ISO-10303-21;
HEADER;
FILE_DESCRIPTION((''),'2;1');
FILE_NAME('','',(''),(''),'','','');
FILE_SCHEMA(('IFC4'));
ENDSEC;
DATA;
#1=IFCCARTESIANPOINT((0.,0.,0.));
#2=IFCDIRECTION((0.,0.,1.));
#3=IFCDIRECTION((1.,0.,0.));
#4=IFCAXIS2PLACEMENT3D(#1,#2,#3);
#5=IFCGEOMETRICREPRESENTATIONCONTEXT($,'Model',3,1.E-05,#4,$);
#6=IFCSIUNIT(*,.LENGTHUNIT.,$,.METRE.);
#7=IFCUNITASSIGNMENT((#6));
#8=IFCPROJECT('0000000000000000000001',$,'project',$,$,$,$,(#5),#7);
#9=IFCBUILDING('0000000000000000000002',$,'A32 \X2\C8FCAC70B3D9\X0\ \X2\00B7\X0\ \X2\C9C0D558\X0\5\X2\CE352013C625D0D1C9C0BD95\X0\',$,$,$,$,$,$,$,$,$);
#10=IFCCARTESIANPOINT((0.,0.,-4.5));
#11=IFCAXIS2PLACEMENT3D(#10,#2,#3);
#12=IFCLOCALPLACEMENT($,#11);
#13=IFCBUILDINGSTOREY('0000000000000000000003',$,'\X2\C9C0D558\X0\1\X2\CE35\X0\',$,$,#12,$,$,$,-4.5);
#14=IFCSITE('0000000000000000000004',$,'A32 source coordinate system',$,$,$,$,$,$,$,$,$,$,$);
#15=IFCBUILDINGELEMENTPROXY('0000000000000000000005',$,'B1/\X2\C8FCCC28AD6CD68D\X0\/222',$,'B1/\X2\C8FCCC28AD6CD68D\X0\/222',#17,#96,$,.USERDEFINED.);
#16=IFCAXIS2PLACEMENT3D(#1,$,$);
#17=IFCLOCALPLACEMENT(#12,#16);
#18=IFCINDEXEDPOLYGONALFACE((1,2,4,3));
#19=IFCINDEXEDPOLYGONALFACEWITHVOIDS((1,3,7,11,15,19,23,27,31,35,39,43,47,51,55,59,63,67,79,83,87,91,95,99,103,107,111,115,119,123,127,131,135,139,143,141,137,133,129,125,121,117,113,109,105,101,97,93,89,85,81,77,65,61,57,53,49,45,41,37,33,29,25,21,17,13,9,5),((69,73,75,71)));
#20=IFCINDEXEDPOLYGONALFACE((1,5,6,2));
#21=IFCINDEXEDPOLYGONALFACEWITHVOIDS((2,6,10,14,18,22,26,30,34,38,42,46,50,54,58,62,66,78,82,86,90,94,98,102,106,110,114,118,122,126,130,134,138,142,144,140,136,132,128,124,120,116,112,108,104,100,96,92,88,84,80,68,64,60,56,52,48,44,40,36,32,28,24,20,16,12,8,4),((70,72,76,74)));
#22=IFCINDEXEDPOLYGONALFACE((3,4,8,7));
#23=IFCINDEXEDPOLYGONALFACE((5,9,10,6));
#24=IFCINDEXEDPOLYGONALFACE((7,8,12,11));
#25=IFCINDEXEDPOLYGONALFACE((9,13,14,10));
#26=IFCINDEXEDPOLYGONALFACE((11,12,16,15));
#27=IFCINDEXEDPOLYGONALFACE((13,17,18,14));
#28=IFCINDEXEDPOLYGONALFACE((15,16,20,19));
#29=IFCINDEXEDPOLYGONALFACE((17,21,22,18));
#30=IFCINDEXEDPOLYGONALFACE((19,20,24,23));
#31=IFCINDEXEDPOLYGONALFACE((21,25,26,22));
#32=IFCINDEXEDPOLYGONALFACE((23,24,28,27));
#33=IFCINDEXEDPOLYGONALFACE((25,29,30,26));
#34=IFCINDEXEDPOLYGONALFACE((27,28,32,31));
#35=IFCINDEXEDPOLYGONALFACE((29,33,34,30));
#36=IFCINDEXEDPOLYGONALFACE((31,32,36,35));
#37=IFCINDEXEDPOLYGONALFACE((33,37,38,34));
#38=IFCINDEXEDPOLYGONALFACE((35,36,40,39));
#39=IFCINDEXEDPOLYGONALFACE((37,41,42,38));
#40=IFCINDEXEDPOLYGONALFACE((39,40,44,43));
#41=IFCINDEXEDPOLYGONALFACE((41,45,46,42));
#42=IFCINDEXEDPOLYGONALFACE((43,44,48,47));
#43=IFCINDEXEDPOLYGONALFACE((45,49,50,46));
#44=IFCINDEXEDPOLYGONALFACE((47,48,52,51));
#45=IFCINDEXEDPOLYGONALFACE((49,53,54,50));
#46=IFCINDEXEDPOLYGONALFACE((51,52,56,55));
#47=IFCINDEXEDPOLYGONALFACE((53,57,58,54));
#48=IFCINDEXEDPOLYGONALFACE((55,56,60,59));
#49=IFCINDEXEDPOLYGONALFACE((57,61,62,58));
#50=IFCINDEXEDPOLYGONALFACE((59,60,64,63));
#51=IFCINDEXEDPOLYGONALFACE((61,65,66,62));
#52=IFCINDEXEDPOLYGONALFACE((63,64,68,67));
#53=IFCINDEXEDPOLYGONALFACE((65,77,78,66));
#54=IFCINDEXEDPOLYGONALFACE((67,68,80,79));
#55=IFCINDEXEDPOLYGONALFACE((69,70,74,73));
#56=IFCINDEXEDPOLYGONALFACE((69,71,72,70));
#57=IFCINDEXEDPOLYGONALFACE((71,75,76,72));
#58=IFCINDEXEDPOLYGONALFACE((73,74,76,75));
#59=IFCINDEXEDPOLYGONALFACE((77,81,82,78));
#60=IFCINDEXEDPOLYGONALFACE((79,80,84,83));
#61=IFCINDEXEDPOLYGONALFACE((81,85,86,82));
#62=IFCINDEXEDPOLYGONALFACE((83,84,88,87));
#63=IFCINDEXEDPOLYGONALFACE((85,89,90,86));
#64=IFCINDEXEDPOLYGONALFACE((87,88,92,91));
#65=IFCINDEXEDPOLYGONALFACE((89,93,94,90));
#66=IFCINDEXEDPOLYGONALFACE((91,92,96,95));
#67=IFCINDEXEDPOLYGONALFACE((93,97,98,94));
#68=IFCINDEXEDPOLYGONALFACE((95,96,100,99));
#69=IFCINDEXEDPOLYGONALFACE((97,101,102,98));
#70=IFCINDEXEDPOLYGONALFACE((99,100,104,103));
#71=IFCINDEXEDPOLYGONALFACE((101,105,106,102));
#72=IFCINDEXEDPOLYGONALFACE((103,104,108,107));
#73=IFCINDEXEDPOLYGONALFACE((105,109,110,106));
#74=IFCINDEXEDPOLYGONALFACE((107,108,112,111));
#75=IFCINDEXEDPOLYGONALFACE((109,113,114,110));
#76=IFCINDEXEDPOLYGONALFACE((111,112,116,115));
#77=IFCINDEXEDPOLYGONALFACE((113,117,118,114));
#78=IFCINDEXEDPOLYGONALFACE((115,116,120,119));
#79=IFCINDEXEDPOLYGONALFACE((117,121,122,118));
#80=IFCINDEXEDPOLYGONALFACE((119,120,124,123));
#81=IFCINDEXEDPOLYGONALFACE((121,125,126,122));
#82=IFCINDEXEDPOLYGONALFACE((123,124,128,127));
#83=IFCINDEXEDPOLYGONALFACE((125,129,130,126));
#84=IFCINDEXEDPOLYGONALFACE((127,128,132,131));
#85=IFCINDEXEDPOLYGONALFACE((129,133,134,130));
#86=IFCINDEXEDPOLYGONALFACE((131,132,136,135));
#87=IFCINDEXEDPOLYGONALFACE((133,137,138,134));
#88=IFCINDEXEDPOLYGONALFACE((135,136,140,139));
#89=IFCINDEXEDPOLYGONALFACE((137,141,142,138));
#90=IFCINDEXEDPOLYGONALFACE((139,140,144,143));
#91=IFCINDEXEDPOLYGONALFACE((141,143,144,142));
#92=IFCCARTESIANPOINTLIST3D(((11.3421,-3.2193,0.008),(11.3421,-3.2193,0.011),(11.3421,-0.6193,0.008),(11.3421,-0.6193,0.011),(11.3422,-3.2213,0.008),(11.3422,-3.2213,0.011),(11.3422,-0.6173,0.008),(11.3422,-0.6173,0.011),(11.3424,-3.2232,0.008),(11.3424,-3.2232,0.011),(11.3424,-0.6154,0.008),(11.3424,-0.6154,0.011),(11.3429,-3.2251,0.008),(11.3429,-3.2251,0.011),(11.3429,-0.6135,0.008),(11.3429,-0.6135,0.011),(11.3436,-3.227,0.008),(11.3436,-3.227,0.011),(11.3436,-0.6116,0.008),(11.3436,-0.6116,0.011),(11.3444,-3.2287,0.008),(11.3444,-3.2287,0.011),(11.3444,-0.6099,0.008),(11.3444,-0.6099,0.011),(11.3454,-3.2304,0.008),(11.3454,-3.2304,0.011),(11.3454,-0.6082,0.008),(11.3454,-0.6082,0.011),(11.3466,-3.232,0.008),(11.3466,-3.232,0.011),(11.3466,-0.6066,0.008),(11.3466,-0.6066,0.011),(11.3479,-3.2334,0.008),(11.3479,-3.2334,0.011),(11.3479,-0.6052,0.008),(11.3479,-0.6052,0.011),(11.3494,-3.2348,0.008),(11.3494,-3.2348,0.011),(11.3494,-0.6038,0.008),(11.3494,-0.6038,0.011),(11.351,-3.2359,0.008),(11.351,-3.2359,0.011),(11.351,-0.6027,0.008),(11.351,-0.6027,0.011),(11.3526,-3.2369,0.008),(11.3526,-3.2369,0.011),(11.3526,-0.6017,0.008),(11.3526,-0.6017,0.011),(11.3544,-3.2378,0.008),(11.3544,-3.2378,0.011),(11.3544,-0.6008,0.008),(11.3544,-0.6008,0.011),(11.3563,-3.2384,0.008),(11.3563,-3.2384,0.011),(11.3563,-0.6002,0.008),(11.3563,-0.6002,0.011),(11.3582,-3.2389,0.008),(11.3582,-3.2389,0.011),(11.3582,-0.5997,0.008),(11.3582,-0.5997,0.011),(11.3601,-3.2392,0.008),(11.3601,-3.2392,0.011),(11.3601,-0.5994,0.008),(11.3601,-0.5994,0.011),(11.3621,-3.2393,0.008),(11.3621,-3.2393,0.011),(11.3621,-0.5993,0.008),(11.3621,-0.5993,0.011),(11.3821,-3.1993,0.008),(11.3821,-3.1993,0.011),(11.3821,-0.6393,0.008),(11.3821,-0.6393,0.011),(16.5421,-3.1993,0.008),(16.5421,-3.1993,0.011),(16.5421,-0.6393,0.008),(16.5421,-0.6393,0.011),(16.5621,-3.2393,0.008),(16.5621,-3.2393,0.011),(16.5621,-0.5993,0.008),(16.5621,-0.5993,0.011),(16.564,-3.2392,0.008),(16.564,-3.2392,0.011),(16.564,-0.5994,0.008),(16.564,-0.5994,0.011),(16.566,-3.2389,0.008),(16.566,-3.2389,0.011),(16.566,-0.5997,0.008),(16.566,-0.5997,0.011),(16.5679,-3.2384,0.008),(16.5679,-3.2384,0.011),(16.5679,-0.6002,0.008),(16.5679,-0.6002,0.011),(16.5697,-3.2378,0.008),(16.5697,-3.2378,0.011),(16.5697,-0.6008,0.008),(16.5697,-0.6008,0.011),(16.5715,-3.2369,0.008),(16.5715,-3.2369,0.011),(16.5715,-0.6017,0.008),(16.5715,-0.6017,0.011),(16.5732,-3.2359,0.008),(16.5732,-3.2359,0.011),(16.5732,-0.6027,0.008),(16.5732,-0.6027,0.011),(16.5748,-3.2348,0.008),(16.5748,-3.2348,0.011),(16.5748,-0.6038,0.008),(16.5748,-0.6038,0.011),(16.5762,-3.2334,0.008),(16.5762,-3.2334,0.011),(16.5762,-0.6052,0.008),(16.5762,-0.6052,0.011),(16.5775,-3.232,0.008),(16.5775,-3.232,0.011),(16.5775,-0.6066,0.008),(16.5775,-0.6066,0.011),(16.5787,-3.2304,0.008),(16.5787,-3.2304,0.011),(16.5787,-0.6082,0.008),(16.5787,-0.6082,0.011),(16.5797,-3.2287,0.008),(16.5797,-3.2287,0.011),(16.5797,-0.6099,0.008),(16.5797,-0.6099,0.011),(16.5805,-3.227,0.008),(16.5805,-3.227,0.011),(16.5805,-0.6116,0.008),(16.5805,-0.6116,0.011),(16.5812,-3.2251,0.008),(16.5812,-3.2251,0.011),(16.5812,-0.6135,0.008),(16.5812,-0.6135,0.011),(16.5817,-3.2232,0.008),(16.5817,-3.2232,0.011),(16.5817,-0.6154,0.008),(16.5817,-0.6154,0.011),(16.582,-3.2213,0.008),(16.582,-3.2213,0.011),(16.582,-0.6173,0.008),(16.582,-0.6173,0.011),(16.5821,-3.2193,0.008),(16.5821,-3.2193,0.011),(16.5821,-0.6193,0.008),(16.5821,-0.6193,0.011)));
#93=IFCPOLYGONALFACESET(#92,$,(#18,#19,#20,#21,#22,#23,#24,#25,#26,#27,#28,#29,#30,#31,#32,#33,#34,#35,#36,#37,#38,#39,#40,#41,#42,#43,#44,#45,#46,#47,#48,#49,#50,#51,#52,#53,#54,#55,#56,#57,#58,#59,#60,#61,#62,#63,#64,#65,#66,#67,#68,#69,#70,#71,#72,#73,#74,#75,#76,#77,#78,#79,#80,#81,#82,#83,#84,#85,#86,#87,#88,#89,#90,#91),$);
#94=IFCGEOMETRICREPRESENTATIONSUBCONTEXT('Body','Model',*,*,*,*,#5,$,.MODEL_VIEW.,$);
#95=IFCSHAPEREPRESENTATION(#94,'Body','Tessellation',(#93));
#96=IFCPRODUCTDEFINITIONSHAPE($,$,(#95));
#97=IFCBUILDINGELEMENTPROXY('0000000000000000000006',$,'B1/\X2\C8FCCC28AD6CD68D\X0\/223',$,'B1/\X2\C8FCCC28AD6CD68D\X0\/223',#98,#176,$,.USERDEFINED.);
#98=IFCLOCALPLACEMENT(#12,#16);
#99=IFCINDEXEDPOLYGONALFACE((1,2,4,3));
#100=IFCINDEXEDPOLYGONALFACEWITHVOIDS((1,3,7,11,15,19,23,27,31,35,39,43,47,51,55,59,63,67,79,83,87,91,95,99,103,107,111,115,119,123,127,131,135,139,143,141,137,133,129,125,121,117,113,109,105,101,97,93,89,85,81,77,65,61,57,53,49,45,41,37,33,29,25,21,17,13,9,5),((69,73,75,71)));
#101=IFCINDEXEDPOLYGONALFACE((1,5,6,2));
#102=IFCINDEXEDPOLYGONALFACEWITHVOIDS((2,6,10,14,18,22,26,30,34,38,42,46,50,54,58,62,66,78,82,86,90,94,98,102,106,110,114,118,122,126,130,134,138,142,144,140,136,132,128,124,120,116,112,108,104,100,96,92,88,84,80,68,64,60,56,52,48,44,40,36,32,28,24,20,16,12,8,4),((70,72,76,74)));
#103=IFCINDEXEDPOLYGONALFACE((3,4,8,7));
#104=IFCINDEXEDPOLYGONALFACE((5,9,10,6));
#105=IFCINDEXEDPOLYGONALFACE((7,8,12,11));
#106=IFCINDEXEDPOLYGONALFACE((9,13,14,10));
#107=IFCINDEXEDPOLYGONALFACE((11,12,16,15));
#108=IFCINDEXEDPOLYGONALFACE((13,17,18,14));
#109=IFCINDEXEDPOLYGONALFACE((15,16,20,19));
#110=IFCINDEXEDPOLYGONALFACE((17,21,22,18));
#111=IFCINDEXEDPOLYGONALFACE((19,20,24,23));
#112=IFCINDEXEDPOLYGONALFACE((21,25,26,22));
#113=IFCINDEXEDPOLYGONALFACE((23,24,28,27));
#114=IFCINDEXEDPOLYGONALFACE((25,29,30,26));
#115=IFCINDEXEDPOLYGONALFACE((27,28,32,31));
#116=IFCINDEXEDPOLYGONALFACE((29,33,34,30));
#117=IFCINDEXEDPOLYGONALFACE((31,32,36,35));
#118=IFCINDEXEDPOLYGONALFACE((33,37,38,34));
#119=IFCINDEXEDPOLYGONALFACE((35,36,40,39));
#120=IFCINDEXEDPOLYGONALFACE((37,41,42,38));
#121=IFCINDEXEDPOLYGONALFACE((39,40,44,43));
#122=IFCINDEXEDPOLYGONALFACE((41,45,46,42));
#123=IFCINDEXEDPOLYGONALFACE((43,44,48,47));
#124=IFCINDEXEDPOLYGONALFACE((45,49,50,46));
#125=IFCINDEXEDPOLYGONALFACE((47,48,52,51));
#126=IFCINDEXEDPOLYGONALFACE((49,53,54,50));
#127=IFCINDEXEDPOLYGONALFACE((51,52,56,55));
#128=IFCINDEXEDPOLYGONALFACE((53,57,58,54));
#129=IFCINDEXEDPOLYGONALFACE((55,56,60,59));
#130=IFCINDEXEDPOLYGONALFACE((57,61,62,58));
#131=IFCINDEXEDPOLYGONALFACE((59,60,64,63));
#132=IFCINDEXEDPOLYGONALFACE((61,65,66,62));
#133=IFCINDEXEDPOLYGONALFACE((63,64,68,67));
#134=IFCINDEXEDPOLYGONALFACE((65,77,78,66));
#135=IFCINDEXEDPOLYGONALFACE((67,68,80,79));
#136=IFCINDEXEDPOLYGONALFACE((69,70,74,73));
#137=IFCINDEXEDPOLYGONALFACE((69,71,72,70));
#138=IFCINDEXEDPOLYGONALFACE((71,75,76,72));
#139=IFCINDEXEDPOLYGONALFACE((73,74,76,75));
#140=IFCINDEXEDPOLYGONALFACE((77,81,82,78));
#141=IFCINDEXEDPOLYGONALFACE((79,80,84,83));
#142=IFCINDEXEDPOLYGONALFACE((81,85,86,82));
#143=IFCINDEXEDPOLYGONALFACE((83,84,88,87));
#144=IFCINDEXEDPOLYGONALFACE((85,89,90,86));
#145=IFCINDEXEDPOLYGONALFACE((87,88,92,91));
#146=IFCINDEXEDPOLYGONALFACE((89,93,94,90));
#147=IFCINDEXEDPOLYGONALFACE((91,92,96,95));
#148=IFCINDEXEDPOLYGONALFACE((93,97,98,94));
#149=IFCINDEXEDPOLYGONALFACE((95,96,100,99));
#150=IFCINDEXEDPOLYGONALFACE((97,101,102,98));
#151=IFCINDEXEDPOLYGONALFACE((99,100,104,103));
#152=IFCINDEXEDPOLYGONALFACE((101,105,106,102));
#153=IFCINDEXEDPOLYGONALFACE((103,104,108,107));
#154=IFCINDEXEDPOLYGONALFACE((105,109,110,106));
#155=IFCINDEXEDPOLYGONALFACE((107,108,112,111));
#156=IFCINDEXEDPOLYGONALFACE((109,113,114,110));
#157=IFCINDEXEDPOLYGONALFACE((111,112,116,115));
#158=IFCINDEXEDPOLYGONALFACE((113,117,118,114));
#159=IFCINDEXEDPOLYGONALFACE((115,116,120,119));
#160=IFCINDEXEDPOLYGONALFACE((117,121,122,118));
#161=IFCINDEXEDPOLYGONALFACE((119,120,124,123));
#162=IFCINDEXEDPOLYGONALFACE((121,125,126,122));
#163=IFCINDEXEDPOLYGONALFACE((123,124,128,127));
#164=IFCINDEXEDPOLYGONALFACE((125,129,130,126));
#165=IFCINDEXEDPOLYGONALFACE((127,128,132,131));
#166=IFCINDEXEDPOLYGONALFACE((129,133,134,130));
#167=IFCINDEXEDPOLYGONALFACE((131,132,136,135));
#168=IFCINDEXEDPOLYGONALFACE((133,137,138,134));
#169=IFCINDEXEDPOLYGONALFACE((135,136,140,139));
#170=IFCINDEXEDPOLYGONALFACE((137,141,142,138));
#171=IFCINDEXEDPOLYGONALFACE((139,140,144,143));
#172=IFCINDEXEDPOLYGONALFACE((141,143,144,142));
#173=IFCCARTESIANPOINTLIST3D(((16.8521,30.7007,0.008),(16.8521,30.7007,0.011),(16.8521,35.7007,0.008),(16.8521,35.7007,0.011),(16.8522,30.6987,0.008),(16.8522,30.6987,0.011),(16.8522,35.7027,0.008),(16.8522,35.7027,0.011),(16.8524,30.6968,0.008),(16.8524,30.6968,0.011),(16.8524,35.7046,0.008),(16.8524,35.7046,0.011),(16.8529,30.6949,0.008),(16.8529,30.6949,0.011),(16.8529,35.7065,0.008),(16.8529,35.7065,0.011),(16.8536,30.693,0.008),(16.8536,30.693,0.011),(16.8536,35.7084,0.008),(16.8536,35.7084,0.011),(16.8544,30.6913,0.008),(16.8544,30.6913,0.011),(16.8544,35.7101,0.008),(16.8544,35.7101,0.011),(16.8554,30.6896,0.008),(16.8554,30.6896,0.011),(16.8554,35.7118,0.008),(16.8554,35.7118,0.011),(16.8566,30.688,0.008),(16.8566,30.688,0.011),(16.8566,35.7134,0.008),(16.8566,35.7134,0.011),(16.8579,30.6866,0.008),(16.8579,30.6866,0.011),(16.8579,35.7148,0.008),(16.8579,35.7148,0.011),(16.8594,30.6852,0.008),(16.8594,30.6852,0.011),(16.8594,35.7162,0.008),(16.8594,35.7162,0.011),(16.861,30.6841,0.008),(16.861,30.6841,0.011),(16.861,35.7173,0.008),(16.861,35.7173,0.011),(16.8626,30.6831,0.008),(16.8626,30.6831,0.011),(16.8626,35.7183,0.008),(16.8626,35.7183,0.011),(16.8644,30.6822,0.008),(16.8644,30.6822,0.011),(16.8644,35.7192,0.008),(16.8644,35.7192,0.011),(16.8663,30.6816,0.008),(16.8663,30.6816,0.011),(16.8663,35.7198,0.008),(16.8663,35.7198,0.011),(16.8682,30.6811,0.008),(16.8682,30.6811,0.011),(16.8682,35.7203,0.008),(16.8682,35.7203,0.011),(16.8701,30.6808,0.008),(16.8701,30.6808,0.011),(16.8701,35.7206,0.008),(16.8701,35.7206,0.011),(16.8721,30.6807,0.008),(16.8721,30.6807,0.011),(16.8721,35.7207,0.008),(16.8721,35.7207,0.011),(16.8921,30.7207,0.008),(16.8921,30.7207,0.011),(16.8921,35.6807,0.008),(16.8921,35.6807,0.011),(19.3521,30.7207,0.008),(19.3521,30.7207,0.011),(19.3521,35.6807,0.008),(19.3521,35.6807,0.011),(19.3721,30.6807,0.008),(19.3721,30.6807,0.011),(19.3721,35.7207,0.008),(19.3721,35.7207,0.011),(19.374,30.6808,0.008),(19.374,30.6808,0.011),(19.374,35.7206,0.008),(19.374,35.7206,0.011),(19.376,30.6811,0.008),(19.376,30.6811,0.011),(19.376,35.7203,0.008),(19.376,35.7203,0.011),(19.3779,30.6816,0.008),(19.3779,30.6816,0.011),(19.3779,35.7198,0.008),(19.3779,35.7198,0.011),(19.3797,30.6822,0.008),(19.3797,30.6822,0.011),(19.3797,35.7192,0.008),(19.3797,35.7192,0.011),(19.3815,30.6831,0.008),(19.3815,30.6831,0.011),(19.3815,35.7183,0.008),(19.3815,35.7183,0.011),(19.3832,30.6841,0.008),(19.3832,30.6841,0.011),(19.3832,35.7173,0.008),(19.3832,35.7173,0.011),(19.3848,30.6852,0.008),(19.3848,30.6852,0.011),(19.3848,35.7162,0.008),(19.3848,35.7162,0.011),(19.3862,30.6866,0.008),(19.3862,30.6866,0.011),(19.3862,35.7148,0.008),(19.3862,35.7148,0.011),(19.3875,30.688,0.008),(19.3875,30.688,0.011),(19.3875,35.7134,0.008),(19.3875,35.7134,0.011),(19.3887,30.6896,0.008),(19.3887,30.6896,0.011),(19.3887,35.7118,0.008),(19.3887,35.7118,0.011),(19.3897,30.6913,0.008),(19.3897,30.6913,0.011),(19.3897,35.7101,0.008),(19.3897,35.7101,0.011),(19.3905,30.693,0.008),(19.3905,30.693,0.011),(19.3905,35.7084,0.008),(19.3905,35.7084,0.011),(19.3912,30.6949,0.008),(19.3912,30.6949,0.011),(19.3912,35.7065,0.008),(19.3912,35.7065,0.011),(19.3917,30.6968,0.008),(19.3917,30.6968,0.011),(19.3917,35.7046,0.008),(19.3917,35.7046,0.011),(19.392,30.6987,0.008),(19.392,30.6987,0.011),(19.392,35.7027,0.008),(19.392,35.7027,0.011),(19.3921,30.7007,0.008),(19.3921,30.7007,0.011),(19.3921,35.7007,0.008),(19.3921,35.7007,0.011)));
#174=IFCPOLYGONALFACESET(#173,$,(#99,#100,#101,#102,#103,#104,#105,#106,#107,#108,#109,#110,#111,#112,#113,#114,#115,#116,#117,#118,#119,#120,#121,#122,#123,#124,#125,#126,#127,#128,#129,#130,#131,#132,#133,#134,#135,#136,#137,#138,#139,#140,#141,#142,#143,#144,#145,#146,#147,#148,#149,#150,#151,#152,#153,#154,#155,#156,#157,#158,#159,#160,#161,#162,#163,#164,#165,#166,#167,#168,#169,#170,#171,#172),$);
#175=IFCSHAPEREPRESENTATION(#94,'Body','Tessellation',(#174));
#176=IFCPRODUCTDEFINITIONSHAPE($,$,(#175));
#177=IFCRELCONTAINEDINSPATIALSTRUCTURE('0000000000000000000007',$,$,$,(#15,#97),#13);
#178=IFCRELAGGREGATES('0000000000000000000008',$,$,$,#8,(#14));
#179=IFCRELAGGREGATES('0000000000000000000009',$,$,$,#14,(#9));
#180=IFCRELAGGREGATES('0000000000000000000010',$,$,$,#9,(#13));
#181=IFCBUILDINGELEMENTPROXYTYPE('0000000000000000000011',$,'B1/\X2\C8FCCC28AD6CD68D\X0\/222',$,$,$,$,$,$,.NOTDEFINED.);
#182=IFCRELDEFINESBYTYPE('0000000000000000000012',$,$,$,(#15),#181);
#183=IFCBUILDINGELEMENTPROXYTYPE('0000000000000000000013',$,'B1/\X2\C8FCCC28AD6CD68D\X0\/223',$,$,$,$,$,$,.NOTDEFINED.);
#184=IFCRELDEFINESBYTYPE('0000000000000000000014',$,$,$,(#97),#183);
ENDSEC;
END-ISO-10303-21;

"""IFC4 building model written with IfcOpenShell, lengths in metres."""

from ifc_helpers import new_model, si_unit, frame, origin, origin_with_axes, place, context, subcontext, project, spatial, polyline, outline, extrude, source, transform, mapped, type_object, type_shapes, element, save


model = new_model("IFC4")

# Units and contexts
model_context = context("Model", 3, precision=1e-05, world=origin_with_axes())
body_context = subcontext(model_context, "Body", "Model", "MODEL_VIEW")
ifc_project = project(units=[si_unit("LENGTHUNIT", "METRE")], contexts=[model_context])

# Site, building, storey
site = spatial("IfcSite", under=ifc_project, Name="A32 source coordinate system")
building = spatial("IfcBuilding", under=site, Name="A32 주거동 · 지하5층–옥탑지붕")
storey_placement = place(None, frame((0.0, 0.0, -4.5), z_axis=(0.0, 0.0, 1.0), x_axis=(1.0, 0.0, 0.0)))
storey = spatial("IfcBuildingStorey", under=building, at=storey_placement, Name="지하1층", Elevation=-4.5)

# Building element proxies
building_element_proxy_type_1 = type_object("IfcBuildingElementProxyType", Name="B1/주차구획/222", PredefinedType="NOTDEFINED")
shared_shape_1 = source(origin(), body_context, "Body", "SweptSolid", [
    extrude(outline(polyline([(11.3421, -0.6193), (11.3422, -0.6173), (11.3424, -0.6154), (11.3429, -0.6135), (11.3436, -0.6116), (11.3444, -0.6099), (11.3454, -0.6082), (11.3466, -0.6066), (11.3479, -0.6052), (11.3494, -0.6038), (11.351, -0.6027), (11.3526, -0.6017), (11.3544, -0.6008), (11.3563, -0.6002), (11.3582, -0.5997), (11.3601, -0.5994), (11.3621, -0.5993), (16.5621, -0.5993), (16.564, -0.5994), (16.566, -0.5997), (16.5679, -0.6002), (16.5697, -0.6008), (16.5715, -0.6017), (16.5732, -0.6027), (16.5748, -0.6038), (16.5762, -0.6052), (16.5775, -0.6066), (16.5787, -0.6082), (16.5797, -0.6099), (16.5805, -0.6116), (16.5812, -0.6135), (16.5817, -0.6154), (16.582, -0.6173), (16.5821, -0.6193), (16.5821, -3.2193), (16.582, -3.2213), (16.5817, -3.2232), (16.5812, -3.2251), (16.5805, -3.227), (16.5797, -3.2287), (16.5787, -3.2304), (16.5775, -3.232), (16.5762, -3.2334), (16.5748, -3.2348), (16.5732, -3.2359), (16.5715, -3.2369), (16.5697, -3.2378), (16.5679, -3.2384), (16.566, -3.2389), (16.564, -3.2392), (16.5621, -3.2393), (11.3621, -3.2393), (11.3601, -3.2392), (11.3582, -3.2389), (11.3563, -3.2384), (11.3544, -3.2378), (11.3526, -3.2369), (11.351, -3.2359), (11.3494, -3.2348), (11.3479, -3.2334), (11.3466, -3.232), (11.3454, -3.2304), (11.3444, -3.2287), (11.3436, -3.227), (11.3429, -3.2251), (11.3424, -3.2232), (11.3422, -3.2213), (11.3421, -3.2193), (11.3421, -0.6193)]), holes=[polyline([(11.3821, -0.6393), (11.3821, -3.1993), (16.5421, -3.1993), (16.5421, -0.6393), (11.3821, -0.6393)])]), frame((0.0, 0.0, 0.008)), (0.0, 0.0, 1.0), 0.003),
])
type_shapes(building_element_proxy_type_1, [shared_shape_1])
proxy_1_placement = place(storey_placement, origin_with_axes())
element("IfcBuildingElementProxy", 1, at=proxy_1_placement, inside=storey, type_object=building_element_proxy_type_1, Name="B1/주차구획/222", ObjectType="B1/주차구획/222", PredefinedType="USERDEFINED", context=body_context, shape_type="MappedRepresentation", body=[
    mapped(shared_shape_1, transform((0.0, 0.0, 0.0), scale=1.0)),
])
building_element_proxy_type_2 = type_object("IfcBuildingElementProxyType", Name="B1/주차구획/223", PredefinedType="NOTDEFINED")
shared_shape_2 = source(origin(), body_context, "Body", "SweptSolid", [
    extrude(outline(polyline([(16.8521, 35.7007), (16.8522, 35.7027), (16.8524, 35.7046), (16.8529, 35.7065), (16.8536, 35.7084), (16.8544, 35.7101), (16.8554, 35.7118), (16.8566, 35.7134), (16.8579, 35.7148), (16.8594, 35.7162), (16.861, 35.7173), (16.8626, 35.7183), (16.8644, 35.7192), (16.8663, 35.7198), (16.8682, 35.7203), (16.8701, 35.7206), (16.8721, 35.7207), (19.3721, 35.7207), (19.374, 35.7206), (19.376, 35.7203), (19.3779, 35.7198), (19.3797, 35.7192), (19.3815, 35.7183), (19.3832, 35.7173), (19.3848, 35.7162), (19.3862, 35.7148), (19.3875, 35.7134), (19.3887, 35.7118), (19.3897, 35.7101), (19.3905, 35.7084), (19.3912, 35.7065), (19.3917, 35.7046), (19.392, 35.7027), (19.3921, 35.7007), (19.3921, 30.7007), (19.392, 30.6987), (19.3917, 30.6968), (19.3912, 30.6949), (19.3905, 30.693), (19.3897, 30.6913), (19.3887, 30.6896), (19.3875, 30.688), (19.3862, 30.6866), (19.3848, 30.6852), (19.3832, 30.6841), (19.3815, 30.6831), (19.3797, 30.6822), (19.3779, 30.6816), (19.376, 30.6811), (19.374, 30.6808), (19.3721, 30.6807), (16.8721, 30.6807), (16.8701, 30.6808), (16.8682, 30.6811), (16.8663, 30.6816), (16.8644, 30.6822), (16.8626, 30.6831), (16.861, 30.6841), (16.8594, 30.6852), (16.8579, 30.6866), (16.8566, 30.688), (16.8554, 30.6896), (16.8544, 30.6913), (16.8536, 30.693), (16.8529, 30.6949), (16.8524, 30.6968), (16.8522, 30.6987), (16.8521, 30.7007), (16.8521, 35.7007)]), holes=[polyline([(16.8921, 35.6807), (16.8921, 30.7207), (19.3521, 30.7207), (19.3521, 35.6807), (16.8921, 35.6807)])]), frame((0.0, 0.0, 0.008)), (0.0, 0.0, 1.0), 0.003),
])
type_shapes(building_element_proxy_type_2, [shared_shape_2])
proxy_2_placement = place(storey_placement, origin_with_axes())
element("IfcBuildingElementProxy", 2, at=proxy_2_placement, inside=storey, type_object=building_element_proxy_type_2, Name="B1/주차구획/223", ObjectType="B1/주차구획/223", PredefinedType="USERDEFINED", context=body_context, shape_type="MappedRepresentation", body=[
    mapped(shared_shape_2, transform((0.0, 0.0, 0.0), scale=1.0)),
])

save(model, "model.ifc")
